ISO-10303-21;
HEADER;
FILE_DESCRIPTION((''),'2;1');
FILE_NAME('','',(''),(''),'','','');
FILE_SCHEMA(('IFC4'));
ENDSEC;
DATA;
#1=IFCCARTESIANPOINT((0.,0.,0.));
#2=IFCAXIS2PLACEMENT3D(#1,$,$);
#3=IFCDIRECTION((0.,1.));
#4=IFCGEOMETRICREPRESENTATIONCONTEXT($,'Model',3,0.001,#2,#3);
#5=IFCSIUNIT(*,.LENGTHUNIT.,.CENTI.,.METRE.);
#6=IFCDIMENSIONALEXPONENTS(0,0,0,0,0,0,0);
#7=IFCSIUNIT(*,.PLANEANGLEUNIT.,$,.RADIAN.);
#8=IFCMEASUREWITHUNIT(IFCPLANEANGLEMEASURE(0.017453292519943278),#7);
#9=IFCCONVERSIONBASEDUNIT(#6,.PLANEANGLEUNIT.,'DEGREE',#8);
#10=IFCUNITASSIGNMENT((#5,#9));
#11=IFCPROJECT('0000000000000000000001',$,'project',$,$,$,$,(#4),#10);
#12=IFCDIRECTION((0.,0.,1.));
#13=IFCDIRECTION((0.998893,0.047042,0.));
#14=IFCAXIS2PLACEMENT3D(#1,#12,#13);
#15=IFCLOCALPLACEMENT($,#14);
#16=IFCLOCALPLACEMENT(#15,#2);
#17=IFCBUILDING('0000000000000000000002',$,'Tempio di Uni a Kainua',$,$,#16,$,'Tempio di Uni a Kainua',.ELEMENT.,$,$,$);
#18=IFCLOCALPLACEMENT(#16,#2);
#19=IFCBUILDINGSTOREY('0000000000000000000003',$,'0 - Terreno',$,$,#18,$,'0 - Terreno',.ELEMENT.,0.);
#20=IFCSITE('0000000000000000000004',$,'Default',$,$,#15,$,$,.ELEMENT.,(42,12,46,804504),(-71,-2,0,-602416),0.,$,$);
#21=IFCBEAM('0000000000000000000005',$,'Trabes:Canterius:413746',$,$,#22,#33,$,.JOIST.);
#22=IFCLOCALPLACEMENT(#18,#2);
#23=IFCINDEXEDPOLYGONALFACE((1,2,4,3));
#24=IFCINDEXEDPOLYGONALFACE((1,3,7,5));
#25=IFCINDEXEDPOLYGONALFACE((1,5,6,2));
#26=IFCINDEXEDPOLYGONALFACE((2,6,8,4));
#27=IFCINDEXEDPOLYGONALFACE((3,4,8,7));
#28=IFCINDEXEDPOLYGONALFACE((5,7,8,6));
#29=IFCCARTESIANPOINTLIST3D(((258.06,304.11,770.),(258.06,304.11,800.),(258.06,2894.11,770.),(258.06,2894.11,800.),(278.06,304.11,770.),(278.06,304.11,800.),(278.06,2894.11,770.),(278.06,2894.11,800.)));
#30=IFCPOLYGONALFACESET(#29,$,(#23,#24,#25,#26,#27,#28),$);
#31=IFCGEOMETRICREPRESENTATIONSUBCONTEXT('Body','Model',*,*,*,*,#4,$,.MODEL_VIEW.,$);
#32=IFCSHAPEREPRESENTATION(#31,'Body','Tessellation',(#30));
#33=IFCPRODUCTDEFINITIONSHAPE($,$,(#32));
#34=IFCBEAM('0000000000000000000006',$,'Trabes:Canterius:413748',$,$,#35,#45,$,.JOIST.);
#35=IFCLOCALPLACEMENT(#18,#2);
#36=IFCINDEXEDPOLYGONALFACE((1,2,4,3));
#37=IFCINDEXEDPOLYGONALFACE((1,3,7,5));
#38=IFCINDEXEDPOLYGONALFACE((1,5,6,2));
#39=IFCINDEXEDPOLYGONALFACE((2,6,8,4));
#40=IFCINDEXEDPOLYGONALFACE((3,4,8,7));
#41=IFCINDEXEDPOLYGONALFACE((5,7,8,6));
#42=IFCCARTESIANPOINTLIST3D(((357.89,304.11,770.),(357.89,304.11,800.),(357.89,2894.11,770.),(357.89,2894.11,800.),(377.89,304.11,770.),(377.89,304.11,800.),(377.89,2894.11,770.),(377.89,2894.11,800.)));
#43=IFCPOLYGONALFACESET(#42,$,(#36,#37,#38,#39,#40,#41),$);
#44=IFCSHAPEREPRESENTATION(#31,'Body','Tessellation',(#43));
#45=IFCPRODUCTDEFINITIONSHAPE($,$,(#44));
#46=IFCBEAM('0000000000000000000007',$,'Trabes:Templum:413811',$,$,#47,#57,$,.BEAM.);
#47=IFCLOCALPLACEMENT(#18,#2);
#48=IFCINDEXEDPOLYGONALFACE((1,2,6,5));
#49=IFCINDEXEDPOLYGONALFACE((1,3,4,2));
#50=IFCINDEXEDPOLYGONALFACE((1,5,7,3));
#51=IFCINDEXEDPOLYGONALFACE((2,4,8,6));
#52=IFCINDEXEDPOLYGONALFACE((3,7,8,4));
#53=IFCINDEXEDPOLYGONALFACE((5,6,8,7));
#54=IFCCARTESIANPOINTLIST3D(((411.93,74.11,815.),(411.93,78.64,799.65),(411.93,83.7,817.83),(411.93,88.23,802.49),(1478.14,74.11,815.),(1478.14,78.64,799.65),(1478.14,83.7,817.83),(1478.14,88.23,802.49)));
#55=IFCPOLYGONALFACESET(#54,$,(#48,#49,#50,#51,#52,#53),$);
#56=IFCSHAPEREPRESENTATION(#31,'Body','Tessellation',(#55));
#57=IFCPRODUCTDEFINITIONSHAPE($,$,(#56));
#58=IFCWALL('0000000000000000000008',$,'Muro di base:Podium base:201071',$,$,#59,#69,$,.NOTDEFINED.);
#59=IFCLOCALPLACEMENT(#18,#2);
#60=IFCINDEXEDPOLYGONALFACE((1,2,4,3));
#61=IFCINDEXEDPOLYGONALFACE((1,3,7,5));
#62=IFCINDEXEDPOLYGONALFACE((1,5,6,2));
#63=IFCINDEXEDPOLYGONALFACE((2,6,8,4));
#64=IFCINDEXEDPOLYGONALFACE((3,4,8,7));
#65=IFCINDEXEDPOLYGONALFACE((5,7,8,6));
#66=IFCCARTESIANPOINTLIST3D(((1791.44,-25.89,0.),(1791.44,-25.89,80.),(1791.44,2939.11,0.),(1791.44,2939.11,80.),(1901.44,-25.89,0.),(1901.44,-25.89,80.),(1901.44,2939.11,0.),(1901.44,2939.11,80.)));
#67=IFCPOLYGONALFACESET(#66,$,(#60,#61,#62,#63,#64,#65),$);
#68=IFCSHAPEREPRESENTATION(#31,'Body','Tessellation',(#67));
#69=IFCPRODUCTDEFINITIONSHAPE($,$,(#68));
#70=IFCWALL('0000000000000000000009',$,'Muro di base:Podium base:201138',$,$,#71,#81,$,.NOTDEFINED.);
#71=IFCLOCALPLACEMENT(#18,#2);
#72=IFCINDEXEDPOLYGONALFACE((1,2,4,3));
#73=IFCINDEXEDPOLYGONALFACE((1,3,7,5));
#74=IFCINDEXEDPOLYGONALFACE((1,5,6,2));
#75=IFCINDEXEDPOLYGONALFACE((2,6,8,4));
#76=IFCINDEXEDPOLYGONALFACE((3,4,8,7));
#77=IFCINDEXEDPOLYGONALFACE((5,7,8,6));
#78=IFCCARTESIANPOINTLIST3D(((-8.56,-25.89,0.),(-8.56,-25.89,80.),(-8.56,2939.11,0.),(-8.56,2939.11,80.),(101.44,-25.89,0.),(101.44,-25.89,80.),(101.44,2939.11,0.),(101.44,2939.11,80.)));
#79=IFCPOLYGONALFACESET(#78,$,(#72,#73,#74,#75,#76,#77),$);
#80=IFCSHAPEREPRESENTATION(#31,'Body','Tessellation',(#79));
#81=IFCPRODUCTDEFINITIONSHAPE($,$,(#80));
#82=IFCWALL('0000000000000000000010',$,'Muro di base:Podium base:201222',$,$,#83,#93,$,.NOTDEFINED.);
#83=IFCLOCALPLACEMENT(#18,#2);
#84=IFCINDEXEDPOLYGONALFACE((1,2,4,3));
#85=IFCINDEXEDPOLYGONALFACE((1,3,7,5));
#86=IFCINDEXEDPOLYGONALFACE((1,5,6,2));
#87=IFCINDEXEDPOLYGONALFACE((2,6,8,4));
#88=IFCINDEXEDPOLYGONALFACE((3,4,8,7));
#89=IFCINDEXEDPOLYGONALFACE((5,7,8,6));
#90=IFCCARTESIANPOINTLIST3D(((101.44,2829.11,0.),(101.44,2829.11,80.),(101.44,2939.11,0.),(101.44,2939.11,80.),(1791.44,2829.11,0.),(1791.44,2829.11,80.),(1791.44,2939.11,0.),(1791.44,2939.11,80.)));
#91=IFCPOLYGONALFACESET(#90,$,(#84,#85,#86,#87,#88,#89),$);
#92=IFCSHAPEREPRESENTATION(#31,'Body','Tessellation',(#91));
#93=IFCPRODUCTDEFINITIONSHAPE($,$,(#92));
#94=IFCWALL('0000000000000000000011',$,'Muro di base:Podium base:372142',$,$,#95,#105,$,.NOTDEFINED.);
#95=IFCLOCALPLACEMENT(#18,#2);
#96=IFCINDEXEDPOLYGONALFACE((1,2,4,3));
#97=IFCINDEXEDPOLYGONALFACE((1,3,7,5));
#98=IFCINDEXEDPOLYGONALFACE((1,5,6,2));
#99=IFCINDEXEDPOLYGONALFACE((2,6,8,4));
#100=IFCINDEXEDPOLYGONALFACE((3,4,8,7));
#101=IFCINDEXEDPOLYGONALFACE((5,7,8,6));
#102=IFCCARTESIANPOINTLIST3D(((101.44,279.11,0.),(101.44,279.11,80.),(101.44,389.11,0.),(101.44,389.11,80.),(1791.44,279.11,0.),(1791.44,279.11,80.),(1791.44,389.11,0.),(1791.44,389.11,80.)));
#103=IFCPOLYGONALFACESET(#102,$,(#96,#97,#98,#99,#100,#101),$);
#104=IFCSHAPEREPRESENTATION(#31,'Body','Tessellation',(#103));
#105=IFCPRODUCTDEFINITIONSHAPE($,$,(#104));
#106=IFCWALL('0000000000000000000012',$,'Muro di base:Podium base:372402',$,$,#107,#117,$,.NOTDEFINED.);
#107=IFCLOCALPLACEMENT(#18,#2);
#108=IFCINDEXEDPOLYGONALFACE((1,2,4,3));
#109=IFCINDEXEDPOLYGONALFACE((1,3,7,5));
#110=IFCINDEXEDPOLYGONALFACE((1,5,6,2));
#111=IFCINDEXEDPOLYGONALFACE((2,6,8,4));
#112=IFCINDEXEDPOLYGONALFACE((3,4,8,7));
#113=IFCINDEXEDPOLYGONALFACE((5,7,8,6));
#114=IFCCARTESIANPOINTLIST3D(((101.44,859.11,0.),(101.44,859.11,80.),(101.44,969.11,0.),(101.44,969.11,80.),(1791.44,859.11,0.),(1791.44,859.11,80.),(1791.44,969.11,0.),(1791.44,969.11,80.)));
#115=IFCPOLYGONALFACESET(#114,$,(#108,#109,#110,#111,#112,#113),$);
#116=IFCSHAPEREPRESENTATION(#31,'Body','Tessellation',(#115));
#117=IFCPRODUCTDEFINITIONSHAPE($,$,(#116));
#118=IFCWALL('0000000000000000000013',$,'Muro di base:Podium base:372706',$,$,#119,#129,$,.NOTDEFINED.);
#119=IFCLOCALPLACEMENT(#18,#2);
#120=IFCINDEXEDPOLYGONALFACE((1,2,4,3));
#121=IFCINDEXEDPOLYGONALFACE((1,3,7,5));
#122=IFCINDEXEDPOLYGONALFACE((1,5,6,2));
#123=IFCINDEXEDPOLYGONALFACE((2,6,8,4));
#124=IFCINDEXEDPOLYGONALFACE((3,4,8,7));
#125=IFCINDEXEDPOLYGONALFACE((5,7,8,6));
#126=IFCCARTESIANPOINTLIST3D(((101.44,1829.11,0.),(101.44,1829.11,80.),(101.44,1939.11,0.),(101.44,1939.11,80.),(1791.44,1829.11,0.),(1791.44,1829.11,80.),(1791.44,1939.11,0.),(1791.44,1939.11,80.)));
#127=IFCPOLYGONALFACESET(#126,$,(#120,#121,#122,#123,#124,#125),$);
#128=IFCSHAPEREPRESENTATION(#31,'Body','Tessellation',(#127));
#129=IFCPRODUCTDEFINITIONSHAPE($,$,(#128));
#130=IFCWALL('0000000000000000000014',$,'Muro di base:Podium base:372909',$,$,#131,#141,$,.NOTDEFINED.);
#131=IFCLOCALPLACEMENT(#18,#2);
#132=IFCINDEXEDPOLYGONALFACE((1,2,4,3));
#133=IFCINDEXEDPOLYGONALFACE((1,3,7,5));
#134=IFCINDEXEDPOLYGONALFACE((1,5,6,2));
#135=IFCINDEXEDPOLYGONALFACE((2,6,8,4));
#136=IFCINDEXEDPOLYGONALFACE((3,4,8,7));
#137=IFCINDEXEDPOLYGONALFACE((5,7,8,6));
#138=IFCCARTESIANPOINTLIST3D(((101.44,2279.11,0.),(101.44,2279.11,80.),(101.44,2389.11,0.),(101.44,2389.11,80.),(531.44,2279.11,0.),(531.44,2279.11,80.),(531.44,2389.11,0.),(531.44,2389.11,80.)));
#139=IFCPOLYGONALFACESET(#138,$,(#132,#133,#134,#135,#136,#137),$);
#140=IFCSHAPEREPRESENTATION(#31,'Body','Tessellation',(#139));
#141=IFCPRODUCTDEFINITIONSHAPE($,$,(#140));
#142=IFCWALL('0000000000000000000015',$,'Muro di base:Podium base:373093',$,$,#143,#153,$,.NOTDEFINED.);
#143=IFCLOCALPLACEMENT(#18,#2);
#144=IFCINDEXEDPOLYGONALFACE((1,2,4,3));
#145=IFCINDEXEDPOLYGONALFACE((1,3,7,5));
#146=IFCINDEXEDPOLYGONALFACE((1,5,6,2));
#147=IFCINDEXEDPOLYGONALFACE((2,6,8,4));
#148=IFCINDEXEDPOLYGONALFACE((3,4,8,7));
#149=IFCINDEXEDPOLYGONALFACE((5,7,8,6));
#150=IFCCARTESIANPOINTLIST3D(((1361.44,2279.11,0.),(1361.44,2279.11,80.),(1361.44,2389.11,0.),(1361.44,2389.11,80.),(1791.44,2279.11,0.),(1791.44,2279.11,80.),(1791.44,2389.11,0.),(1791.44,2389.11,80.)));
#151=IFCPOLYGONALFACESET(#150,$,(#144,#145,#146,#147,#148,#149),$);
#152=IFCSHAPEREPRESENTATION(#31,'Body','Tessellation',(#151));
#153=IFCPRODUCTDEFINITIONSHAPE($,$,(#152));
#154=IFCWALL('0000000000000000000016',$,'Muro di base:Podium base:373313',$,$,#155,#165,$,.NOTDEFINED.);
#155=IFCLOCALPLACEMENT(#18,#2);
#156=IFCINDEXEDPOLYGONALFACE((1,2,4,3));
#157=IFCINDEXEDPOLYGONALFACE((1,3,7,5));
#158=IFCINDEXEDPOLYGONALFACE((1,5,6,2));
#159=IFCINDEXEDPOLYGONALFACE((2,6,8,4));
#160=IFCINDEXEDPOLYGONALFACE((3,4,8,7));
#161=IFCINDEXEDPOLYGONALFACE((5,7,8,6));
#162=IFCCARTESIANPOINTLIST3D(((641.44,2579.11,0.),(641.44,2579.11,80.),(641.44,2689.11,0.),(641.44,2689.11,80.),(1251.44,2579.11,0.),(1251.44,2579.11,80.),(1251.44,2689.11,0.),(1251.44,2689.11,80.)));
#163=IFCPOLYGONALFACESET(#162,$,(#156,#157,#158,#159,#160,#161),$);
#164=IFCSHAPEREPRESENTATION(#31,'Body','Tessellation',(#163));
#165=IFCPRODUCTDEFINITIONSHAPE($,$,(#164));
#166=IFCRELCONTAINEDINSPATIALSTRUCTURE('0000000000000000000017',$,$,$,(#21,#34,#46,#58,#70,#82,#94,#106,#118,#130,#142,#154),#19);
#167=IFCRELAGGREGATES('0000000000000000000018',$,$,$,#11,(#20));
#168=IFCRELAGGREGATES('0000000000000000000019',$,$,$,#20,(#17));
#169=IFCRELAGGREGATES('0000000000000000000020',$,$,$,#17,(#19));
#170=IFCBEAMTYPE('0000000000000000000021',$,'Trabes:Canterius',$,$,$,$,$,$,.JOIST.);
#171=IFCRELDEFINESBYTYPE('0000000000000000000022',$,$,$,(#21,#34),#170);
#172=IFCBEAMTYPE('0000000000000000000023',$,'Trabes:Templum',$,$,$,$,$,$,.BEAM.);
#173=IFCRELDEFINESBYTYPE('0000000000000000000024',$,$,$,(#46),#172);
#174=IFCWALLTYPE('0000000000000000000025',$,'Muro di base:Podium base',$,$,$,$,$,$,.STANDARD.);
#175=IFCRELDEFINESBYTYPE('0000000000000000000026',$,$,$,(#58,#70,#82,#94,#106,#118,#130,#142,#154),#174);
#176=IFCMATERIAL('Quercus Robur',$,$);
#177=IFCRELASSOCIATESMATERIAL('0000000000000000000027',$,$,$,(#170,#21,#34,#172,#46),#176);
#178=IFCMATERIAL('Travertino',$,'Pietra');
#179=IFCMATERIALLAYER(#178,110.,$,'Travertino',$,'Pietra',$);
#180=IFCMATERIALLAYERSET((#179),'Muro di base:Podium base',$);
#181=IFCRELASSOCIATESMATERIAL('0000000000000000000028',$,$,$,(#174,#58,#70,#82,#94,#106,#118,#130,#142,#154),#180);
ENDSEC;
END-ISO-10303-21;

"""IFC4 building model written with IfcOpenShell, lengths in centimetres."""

from ifc_helpers import new_model, entity, si_unit, converted_unit, direction, frame, frame_2d, origin, origin_2d_with_axis, place, context, subcontext, project, spatial, polyline, rectangle, extrude, clip, bounded_halfspace, source, transform, mapped, material, layer, layer_set, layer_usage, material_profile, profile_set, profile_usage, type_object, type_shapes, element, save


model = new_model("IFC4")

# Units and contexts
model_context = context("Model", 3, precision=0.001, world=origin(), true_north=direction((0.0, 1.0)))
body_context = subcontext(model_context, "Body", "Model", "MODEL_VIEW")
ifc_project = project(units=[si_unit("LENGTHUNIT", "METRE", prefix="CENTI"), converted_unit("PLANEANGLEUNIT", "DEGREE", entity("IfcPlaneAngleMeasure", 0.017453292519943278), si_unit("PLANEANGLEUNIT", "RADIAN"), dimensions=[0, 0, 0, 0, 0, 0, 0])], contexts=[model_context])

# Site, building, storey
site_placement = place(None, frame((0.0, 0.0, 0.0), z_axis=(0.0, 0.0, 1.0), x_axis=(0.998893, 0.047042, 0.0)))
site = spatial("IfcSite", under=ifc_project, at=site_placement, Name="Default", CompositionType="ELEMENT", RefLatitude=(42, 12, 46, 804504), RefLongitude=(-71, -2, 0, -602416), RefElevation=0.0)
building_placement = place(site_placement, origin())
building = spatial("IfcBuilding", under=site, at=building_placement, Name="Tempio di Uni a Kainua", LongName="Tempio di Uni a Kainua", CompositionType="ELEMENT")
storey_placement = place(building_placement, origin())
storey = spatial("IfcBuildingStorey", under=building, at=storey_placement, Name="0 - Terreno", LongName="0 - Terreno", CompositionType="ELEMENT", Elevation=0.0)

# Beams
ifc_material_1 = material(Name="Quercus Robur")
ifc_material_profile_1 = material_profile(ifc_material_1, rectangle(XDim=2590.0, YDim=20.0, at=origin_2d_with_axis()), Name="Canterius")
ifc_profile_set_1 = profile_set([ifc_material_profile_1], Name="Canterius")
ifc_profile_usage_1 = profile_usage(ifc_profile_set_1, cardinal=1)
beam_type_1 = type_object("IfcBeamType", Name="Trabes:Canterius", PredefinedType="JOIST", material=ifc_profile_set_1)
shared_shape_1 = source(origin(), body_context, "Body", "SweptSolid", [
    extrude(rectangle(XDim=20.0, YDim=2590.0, at=origin_2d_with_axis()), frame((-80.0, 0.0, -15.0), z_axis=(0.0, 0.0, 1.0), x_axis=(0.0, -1.0, 0.0)), (0.0, 0.0, 1.0), 30.0),
])
type_shapes(beam_type_1, [shared_shape_1])
for number, where, z_axis, x_axis, name in (
    (1, (268.06, 1679.11, 785.0), (0.0, 0.0, 1.0), (0.0, 1.0, 0.0), "Trabes:Canterius:413746"),
    (2, (367.89, 1679.11, 785.0), (0.0, 0.0, 1.0), (0.0, 1.0, 0.0), "Trabes:Canterius:413748"),
):
    element("IfcBeam", number, at=place(storey_placement, frame(where, z_axis=z_axis, x_axis=x_axis)), inside=storey, type_object=beam_type_1, material=ifc_profile_usage_1, Name=name, PredefinedType="JOIST", context=body_context, shape_type="MappedRepresentation", body=[
        mapped(shared_shape_1, transform((0.0, 0.0, 0.0), scale=1.0)),
    ])
ifc_material_profile_2 = material_profile(ifc_material_1, rectangle(XDim=2875.46, YDim=10.0, at=origin_2d_with_axis()), Name="Templum")
ifc_profile_set_2 = profile_set([ifc_material_profile_2], Name="Templum")
ifc_profile_usage_2 = profile_usage(ifc_profile_set_2, cardinal=9)
beam_type_2 = type_object("IfcBeamType", Name="Trabes:Templum", PredefinedType="BEAM", material=ifc_profile_set_2)
shared_shape_2 = source(origin(), body_context, "Body", "SweptSolid", [
    extrude(rectangle(XDim=1066.21, YDim=10.0, at=frame_2d((0.0, 0.0), x_axis=(1.0, 0.0))), frame((0.0, 0.0, -8.0)), (0.0, 0.0, 1.0), 16.0),
])
type_shapes(beam_type_2, [shared_shape_2])
beam_placement = place(storey_placement, frame((945.03, 81.17, 808.74), z_axis=(0.0, -0.283186, 0.959065), x_axis=(1.0, 0.0, 0.0)))
element("IfcBeam", 3, at=beam_placement, inside=storey, type_object=beam_type_2, material=ifc_profile_usage_2, Name="Trabes:Templum:413811", PredefinedType="BEAM", context=body_context, shape_type="MappedRepresentation", body=[
    mapped(shared_shape_2, transform((0.0, 0.0, 0.0), scale=1.0)),
])

# Walls
ifc_material_2 = material(Name="Travertino", Category="Pietra")
ifc_layer_1 = layer(ifc_material_2, 110.0, Name="Travertino", Category="Pietra")
ifc_layer_set_1 = layer_set([ifc_layer_1], Name="Muro di base:Podium base")
ifc_layer_usage_1 = layer_usage(ifc_layer_set_1, "AXIS2", "NEGATIVE", 55.0)
wall_type_1 = type_object("IfcWallType", Name="Muro di base:Podium base", PredefinedType="STANDARD", material=ifc_layer_set_1)
wall_1_placement = place(storey_placement, frame((1846.44, 2939.11, 0.0), z_axis=(0.0, 0.0, 1.0), x_axis=(0.0, -1.0, 0.0)))
element("IfcWall", 4, at=wall_1_placement, inside=storey, type_object=wall_type_1, material=ifc_layer_usage_1, Name="Muro di base:Podium base:201071", PredefinedType="NOTDEFINED", context=body_context, shape_type="Clipping", body=[
    clip(extrude(rectangle(XDim=2965.0, YDim=110.0, at=frame_2d((1482.5, 0.0), x_axis=(-1.0, 0.0))), origin(), (0.0, 0.0, 1.0), 80.0), bounded_halfspace(frame((0.0, -55.0, 80.0), z_axis=(0.0, 0.0, -1.0), x_axis=(1.0, 0.0, 0.0)), True, frame((0.0, -55.0, 80.0)), polyline([(0.0, 0.0), (110.0, 0.0), (2965.0, 0.0), (2965.0, 110.0), (0.0, 110.0), (0.0, 0.0)]))),
])
ifc_layer_usage_2 = layer_usage(ifc_layer_set_1, "AXIS2", "NEGATIVE", 55.0)
wall_2_placement = place(storey_placement, frame((46.44, 2939.11, 0.0), z_axis=(0.0, 0.0, 1.0), x_axis=(0.0, -1.0, 0.0)))
element("IfcWall", 5, at=wall_2_placement, inside=storey, type_object=wall_type_1, material=ifc_layer_usage_2, Name="Muro di base:Podium base:201138", PredefinedType="NOTDEFINED", context=body_context, shape_type="Clipping", body=[
    clip(extrude(rectangle(XDim=2965.0, YDim=110.0, at=frame_2d((1482.5, 0.0), x_axis=(-1.0, 0.0))), origin(), (0.0, 0.0, 1.0), 80.0), bounded_halfspace(frame((0.0, -55.0, 80.0), z_axis=(0.0, 0.0, -1.0), x_axis=(1.0, 0.0, 0.0)), True, frame((0.0, -55.0, 80.0)), polyline([(0.0, 0.0), (2965.0, 0.0), (2965.0, 110.0), (110.0, 110.0), (0.0, 110.0), (0.0, 0.0)]))),
])
ifc_layer_usage_3 = layer_usage(ifc_layer_set_1, "AXIS2", "NEGATIVE", 55.0)
wall_3_placement = place(storey_placement, frame((1791.44, 2884.11, 0.0), z_axis=(0.0, 0.0, 1.0), x_axis=(-1.0, 0.0, 0.0)))
element("IfcWall", 6, at=wall_3_placement, inside=storey, type_object=wall_type_1, material=ifc_layer_usage_3, Name="Muro di base:Podium base:201222", PredefinedType="NOTDEFINED", context=body_context, shape_type="Clipping", body=[
    clip(extrude(rectangle(XDim=1690.0, YDim=110.0, at=frame_2d((845.0, 0.0), x_axis=(-1.0, 0.0))), origin(), (0.0, 0.0, 1.0), 80.0), bounded_halfspace(frame((0.0, -55.0, 80.0), z_axis=(0.0, 0.0, -1.0), x_axis=(0.0, 1.0, 0.0)), True, frame((0.0, -55.0, 80.0)), polyline([(0.0, 0.0), (1690.0, 0.0), (1690.0, 110.0), (0.0, 110.0), (0.0, 0.0)]))),
])
ifc_layer_usage_4 = layer_usage(ifc_layer_set_1, "AXIS2", "NEGATIVE", 55.0)
wall_4_placement = place(storey_placement, frame((101.44, 334.11, 0.0)))
element("IfcWall", 7, at=wall_4_placement, inside=storey, type_object=wall_type_1, material=ifc_layer_usage_4, Name="Muro di base:Podium base:372142", PredefinedType="NOTDEFINED", context=body_context, shape_type="Clipping", body=[
    clip(extrude(rectangle(XDim=1690.0, YDim=110.0, at=frame_2d((845.0, 0.0), x_axis=(-1.0, 0.0))), origin(), (0.0, 0.0, 1.0), 80.0), bounded_halfspace(frame((0.0, -55.0, 80.0), z_axis=(0.0, 0.0, -1.0), x_axis=(0.0, -1.0, 0.0)), True, frame((0.0, -55.0, 80.0)), polyline([(0.0, 0.0), (5.0, 0.0), (1685.0, 0.0), (1690.0, 0.0), (1690.0, 110.0), (1265.0, 110.0), (1125.0, 110.0), (565.0, 110.0), (425.0, 110.0), (0.0, 110.0), (0.0, 0.0)]))),
])
ifc_layer_usage_5 = layer_usage(ifc_layer_set_1, "AXIS2", "NEGATIVE", 55.0)
wall_5_placement = place(storey_placement, frame((101.44, 914.11, 0.0)))
element("IfcWall", 8, at=wall_5_placement, inside=storey, type_object=wall_type_1, material=ifc_layer_usage_5, Name="Muro di base:Podium base:372402", PredefinedType="NOTDEFINED", context=body_context, shape_type="Clipping", body=[
    clip(extrude(rectangle(XDim=1690.0, YDim=110.0, at=frame_2d((845.0, 0.0), x_axis=(-1.0, 0.0))), origin(), (0.0, 0.0, 1.0), 80.0), bounded_halfspace(frame((0.0, -55.0, 80.0), z_axis=(0.0, 0.0, -1.0), x_axis=(0.0, -1.0, 0.0)), True, frame((0.0, -55.0, 80.0)), polyline([(0.0, 0.0), (1690.0, 0.0), (1690.0, 110.0), (1265.0, 110.0), (1125.0, 110.0), (565.0, 110.0), (425.0, 110.0), (0.0, 110.0), (0.0, 0.0)]))),
])
ifc_layer_usage_6 = layer_usage(ifc_layer_set_1, "AXIS2", "NEGATIVE", 55.0)
wall_6_placement = place(storey_placement, frame((101.44, 1884.11, 0.0)))
element("IfcWall", 9, at=wall_6_placement, inside=storey, type_object=wall_type_1, material=ifc_layer_usage_6, Name="Muro di base:Podium base:372706", PredefinedType="NOTDEFINED", context=body_context, shape_type="Clipping", body=[
    clip(extrude(rectangle(XDim=1690.0, YDim=110.0, at=frame_2d((845.0, 0.0), x_axis=(-1.0, 0.0))), origin(), (0.0, 0.0, 1.0), 80.0), bounded_halfspace(frame((0.0, -55.0, 80.0), z_axis=(0.0, 0.0, -1.0), x_axis=(0.0, -1.0, 0.0)), True, frame((0.0, -55.0, 80.0)), polyline([(0.0, 0.0), (1690.0, 0.0), (1690.0, 110.0), (1260.0, 110.0), (1150.0, 110.0), (540.0, 110.0), (430.0, 110.0), (0.0, 110.0), (0.0, 0.0)]))),
])
ifc_layer_usage_7 = layer_usage(ifc_layer_set_1, "AXIS2", "NEGATIVE", 55.0)
wall_7_placement = place(storey_placement, frame((101.44, 2334.11, 0.0)))
element("IfcWall", 10, at=wall_7_placement, inside=storey, type_object=wall_type_1, material=ifc_layer_usage_7, Name="Muro di base:Podium base:372909", PredefinedType="NOTDEFINED", context=body_context, shape_type="SweptSolid", body=[
    extrude(rectangle(XDim=110.0, YDim=430.0, at=frame_2d((0.0, 0.0), x_axis=(1.0, 0.0))), frame((215.0, 0.0, 0.0), z_axis=(0.0, 0.0, 1.0), x_axis=(0.0, 1.0, 0.0)), (0.0, 0.0, 1.0), 80.0),
])
ifc_layer_usage_8 = layer_usage(ifc_layer_set_1, "AXIS2", "NEGATIVE", 55.0)
wall_8_placement = place(storey_placement, frame((1361.44, 2334.11, 0.0)))
element("IfcWall", 11, at=wall_8_placement, inside=storey, type_object=wall_type_1, material=ifc_layer_usage_8, Name="Muro di base:Podium base:373093", PredefinedType="NOTDEFINED", context=body_context, shape_type="SweptSolid", body=[
    extrude(rectangle(XDim=110.0, YDim=430.0, at=frame_2d((0.0, 0.0), x_axis=(1.0, 0.0))), frame((215.0, 0.0, 0.0), z_axis=(0.0, 0.0, 1.0), x_axis=(0.0, 1.0, 0.0)), (0.0, 0.0, 1.0), 80.0),
])
ifc_layer_usage_9 = layer_usage(ifc_layer_set_1, "AXIS2", "NEGATIVE", 55.0)
wall_9_placement = place(storey_placement, frame((641.44, 2634.11, 0.0)))
element("IfcWall", 12, at=wall_9_placement, inside=storey, type_object=wall_type_1, material=ifc_layer_usage_9, Name="Muro di base:Podium base:373313", PredefinedType="NOTDEFINED", context=body_context, shape_type="SweptSolid", body=[
    extrude(rectangle(XDim=110.0, YDim=610.0, at=frame_2d((0.0, 0.0), x_axis=(1.0, 0.0))), frame((305.0, 0.0, 0.0), z_axis=(0.0, 0.0, 1.0), x_axis=(0.0, 1.0, 0.0)), (0.0, 0.0, 1.0), 80.0),
])

save(model, "model.ifc")
